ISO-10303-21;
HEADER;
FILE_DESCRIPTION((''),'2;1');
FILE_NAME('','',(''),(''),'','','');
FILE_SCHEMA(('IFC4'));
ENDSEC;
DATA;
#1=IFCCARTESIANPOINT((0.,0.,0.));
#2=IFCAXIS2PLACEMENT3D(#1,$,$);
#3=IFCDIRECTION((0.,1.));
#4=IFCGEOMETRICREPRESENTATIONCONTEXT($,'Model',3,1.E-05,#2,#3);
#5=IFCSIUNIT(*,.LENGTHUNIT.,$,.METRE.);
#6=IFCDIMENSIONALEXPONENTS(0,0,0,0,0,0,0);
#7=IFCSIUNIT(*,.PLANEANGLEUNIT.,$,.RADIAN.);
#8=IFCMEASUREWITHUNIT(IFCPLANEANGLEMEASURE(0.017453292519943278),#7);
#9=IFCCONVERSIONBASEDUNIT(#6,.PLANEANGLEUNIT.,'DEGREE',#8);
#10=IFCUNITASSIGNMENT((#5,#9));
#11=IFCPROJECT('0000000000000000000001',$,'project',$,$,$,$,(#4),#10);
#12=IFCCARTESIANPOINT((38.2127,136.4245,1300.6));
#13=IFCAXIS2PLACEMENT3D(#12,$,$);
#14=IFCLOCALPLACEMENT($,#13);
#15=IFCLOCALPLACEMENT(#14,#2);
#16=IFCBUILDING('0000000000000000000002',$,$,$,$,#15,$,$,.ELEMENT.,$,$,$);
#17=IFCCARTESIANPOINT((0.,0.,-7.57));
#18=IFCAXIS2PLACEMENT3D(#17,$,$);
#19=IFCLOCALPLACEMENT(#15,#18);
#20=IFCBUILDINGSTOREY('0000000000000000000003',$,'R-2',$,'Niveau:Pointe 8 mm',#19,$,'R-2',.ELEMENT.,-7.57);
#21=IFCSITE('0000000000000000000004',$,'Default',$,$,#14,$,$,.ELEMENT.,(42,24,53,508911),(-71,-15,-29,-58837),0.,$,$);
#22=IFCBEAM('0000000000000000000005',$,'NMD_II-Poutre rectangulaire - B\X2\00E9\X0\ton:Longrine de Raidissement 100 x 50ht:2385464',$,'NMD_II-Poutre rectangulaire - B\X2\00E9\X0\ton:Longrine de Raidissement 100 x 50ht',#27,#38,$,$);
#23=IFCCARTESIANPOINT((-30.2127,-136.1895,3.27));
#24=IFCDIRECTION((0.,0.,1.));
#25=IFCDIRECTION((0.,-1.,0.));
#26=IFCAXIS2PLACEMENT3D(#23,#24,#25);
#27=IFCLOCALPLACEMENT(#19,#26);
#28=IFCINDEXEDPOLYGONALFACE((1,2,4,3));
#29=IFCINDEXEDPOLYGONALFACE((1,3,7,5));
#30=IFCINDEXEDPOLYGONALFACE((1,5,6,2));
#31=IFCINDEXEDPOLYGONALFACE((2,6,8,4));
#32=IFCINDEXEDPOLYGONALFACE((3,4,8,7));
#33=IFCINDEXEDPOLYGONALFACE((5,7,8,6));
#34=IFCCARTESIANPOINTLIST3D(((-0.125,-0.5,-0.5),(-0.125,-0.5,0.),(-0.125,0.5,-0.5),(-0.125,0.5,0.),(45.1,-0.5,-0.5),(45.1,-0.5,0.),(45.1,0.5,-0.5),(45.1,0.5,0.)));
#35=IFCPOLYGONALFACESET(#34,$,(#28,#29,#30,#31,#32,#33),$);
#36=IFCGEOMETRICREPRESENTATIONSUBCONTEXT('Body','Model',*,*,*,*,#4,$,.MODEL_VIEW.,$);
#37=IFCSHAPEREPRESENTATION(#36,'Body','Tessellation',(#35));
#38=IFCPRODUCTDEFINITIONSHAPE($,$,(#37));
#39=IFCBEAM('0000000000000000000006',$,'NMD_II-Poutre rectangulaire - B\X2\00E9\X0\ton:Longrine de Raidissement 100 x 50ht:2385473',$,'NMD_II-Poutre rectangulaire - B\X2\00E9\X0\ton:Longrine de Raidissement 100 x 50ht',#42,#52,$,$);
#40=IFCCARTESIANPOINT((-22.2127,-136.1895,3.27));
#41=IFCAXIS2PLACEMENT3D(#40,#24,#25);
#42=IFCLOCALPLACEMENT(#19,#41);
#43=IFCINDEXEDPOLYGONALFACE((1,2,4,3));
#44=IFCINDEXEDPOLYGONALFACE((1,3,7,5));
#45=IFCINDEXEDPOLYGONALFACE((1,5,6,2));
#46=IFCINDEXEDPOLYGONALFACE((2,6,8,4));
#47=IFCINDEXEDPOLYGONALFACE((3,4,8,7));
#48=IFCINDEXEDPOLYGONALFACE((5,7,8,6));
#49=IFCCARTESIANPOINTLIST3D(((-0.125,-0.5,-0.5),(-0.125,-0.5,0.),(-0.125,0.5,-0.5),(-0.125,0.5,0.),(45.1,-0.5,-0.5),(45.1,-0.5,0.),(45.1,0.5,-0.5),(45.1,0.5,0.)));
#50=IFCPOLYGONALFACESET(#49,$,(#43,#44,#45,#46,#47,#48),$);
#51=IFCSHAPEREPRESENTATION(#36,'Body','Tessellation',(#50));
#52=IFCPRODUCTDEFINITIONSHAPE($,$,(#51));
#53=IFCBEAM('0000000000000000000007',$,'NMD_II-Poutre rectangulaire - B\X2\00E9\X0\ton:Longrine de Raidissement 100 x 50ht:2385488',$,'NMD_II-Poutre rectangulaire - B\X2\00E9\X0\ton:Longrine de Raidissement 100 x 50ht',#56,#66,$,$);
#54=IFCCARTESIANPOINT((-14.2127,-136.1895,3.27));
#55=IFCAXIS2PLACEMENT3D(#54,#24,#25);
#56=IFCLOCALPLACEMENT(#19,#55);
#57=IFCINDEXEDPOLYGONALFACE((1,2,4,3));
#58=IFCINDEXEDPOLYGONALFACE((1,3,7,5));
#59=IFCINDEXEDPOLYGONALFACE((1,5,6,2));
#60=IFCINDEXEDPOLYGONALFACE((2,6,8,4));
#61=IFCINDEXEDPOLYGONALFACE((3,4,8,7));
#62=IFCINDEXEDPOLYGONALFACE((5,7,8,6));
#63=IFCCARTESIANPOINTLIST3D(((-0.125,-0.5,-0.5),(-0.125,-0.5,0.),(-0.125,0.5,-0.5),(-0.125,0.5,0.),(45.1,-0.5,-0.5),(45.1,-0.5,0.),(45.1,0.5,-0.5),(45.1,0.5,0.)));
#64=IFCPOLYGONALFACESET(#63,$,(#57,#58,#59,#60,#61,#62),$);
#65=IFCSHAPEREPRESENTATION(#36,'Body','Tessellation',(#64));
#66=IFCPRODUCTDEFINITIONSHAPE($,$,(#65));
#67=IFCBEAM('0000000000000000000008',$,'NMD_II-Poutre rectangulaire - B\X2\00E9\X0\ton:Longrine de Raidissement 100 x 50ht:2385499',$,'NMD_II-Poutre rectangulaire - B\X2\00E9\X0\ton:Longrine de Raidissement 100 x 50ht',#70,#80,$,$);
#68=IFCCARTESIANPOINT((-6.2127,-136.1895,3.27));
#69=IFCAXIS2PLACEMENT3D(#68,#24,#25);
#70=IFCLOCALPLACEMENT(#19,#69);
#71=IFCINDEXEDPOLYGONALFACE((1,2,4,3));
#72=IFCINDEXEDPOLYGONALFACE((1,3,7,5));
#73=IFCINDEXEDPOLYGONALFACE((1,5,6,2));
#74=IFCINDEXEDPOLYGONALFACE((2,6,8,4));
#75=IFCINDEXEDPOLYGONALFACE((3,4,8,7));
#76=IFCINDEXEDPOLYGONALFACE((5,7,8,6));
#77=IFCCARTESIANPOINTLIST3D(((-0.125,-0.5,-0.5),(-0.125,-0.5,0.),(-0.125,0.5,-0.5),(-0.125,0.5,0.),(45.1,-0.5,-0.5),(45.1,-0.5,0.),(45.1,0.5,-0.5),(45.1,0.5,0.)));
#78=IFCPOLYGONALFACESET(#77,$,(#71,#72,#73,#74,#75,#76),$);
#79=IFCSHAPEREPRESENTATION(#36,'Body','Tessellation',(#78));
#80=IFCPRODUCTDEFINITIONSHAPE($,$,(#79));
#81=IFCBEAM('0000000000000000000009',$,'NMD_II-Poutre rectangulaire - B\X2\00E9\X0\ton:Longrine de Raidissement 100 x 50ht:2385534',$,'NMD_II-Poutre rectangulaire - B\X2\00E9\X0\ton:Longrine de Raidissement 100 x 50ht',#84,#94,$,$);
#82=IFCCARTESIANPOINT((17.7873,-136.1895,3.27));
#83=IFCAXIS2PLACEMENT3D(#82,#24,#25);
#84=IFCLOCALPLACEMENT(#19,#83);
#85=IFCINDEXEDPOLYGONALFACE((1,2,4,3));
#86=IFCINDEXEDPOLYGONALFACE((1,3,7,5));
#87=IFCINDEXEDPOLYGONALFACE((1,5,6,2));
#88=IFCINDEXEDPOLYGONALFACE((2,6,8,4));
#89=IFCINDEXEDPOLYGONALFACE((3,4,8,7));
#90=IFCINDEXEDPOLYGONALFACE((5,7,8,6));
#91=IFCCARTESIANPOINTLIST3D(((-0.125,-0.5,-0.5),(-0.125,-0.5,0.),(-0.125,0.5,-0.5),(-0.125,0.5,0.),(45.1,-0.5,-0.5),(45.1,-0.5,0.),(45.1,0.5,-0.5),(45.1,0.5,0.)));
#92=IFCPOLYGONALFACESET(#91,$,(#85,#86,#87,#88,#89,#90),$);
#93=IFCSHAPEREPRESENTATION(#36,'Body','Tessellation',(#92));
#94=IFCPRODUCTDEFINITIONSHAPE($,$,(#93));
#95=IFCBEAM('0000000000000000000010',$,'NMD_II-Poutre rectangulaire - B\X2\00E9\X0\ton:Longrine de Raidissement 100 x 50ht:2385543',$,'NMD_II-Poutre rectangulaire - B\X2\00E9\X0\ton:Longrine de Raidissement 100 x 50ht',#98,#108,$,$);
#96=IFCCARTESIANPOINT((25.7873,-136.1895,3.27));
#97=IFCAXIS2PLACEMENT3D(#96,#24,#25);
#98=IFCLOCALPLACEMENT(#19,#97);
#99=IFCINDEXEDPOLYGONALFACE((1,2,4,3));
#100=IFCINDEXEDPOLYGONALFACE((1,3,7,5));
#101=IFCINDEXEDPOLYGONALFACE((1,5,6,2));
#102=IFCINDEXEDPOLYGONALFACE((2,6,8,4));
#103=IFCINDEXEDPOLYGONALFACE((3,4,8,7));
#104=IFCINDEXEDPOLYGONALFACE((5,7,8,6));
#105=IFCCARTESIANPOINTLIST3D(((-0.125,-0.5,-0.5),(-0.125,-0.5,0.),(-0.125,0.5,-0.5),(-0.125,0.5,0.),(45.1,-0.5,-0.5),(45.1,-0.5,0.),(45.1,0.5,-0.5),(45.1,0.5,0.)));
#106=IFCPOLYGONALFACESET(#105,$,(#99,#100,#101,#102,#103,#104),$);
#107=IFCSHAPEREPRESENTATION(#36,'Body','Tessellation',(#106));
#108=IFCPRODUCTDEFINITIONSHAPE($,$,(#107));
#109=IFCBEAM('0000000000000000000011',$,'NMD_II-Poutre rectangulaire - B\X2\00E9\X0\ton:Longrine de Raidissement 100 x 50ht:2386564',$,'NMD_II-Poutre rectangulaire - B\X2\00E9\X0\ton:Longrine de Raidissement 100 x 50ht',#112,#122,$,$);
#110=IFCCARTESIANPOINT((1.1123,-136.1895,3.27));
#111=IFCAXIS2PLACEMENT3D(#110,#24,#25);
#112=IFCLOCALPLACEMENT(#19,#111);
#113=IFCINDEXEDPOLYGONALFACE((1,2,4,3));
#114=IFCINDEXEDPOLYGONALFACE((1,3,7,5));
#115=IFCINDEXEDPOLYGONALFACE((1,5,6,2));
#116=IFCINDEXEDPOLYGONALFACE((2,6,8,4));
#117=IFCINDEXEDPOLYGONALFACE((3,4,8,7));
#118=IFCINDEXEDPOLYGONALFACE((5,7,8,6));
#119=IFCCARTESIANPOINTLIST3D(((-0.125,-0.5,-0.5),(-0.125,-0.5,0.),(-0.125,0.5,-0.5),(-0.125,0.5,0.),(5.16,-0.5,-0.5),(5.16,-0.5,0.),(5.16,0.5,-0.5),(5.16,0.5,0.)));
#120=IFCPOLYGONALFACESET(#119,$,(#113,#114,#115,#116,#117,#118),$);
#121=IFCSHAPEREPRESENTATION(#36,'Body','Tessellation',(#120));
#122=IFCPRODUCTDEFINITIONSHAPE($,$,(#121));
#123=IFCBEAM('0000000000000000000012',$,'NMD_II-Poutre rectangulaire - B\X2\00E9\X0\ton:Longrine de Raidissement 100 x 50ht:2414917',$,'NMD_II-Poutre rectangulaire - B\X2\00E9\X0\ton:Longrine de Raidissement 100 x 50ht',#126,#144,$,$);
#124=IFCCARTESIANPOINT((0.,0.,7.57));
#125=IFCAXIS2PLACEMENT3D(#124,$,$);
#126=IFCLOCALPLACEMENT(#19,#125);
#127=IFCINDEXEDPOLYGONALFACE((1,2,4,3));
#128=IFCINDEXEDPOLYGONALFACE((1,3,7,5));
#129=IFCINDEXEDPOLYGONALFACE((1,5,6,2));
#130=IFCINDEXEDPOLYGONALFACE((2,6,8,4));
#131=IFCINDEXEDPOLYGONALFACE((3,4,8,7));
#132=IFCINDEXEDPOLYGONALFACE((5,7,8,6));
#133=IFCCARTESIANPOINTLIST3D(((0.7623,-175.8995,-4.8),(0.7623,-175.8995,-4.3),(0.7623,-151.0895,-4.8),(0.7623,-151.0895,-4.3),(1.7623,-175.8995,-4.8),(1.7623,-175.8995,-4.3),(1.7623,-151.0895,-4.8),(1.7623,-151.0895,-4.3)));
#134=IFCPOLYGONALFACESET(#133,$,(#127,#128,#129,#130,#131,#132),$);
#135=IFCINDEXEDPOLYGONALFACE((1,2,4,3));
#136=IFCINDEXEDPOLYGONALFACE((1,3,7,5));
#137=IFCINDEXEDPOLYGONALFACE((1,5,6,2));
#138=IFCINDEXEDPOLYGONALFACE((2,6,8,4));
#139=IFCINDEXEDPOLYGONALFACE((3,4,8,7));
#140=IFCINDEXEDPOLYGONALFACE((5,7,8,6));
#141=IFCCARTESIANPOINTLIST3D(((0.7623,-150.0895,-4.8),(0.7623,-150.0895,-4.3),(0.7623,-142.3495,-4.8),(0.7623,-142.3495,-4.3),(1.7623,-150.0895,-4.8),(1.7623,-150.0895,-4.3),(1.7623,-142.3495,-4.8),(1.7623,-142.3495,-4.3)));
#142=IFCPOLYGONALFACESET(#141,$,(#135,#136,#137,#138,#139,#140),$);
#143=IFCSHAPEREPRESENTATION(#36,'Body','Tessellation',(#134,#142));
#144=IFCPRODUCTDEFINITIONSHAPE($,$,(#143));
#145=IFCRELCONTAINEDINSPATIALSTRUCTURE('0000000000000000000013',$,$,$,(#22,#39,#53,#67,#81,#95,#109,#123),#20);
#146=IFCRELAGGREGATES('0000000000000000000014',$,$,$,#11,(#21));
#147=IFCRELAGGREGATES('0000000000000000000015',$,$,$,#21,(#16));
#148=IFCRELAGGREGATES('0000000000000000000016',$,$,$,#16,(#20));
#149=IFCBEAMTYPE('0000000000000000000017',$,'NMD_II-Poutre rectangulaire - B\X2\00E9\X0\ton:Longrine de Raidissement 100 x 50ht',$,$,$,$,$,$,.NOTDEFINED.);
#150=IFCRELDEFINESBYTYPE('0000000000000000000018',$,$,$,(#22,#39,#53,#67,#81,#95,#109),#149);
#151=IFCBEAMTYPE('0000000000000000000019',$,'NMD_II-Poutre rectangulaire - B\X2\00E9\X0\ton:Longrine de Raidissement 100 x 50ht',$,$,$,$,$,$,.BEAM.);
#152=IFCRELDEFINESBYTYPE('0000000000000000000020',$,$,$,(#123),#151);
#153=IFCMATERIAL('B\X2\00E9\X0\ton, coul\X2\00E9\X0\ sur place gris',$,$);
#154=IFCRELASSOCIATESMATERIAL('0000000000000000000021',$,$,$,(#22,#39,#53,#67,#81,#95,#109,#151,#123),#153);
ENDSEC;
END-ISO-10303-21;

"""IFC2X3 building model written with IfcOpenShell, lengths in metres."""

from ifc_helpers import new_model, entity, si_unit, converted_unit, direction, frame, frame_2d, origin, place, context, subcontext, project, spatial, rectangle, extrude, source, transform, mapped, material, type_object, type_shapes, element, save


model = new_model("IFC2X3")

# Units and contexts
model_context = context("Model", 3, precision=1e-05, world=origin(), true_north=direction((0.0, 1.0)))
body_context = subcontext(model_context, "Body", "Model", "MODEL_VIEW")
ifc_project = project(units=[si_unit("LENGTHUNIT", "METRE"), converted_unit("PLANEANGLEUNIT", "DEGREE", entity("IfcPlaneAngleMeasure", 0.017453292519943278), si_unit("PLANEANGLEUNIT", "RADIAN"), dimensions=[0, 0, 0, 0, 0, 0, 0])], contexts=[model_context])

# Site, building, storey
site_placement = place(None, frame((38.2127, 136.4245, 1300.6)))
site = spatial("IfcSite", under=ifc_project, at=site_placement, Name="Default", CompositionType="ELEMENT", RefLatitude=(42, 24, 53, 508911), RefLongitude=(-71, -15, -29, -58837), RefElevation=0.0)
building_placement = place(site_placement, origin())
building = spatial("IfcBuilding", under=site, at=building_placement, CompositionType="ELEMENT")
storey_placement = place(building_placement, frame((0.0, 0.0, -7.57)))
storey = spatial("IfcBuildingStorey", under=building, at=storey_placement, Name="R-2", ObjectType="Niveau:Pointe 8 mm", LongName="R-2", CompositionType="ELEMENT", Elevation=-7.57)

# Beams
ifc_material_1 = material(Name="Béton, coulé sur place gris")
beam_type_1 = type_object("IfcBeamType", Name="NMD_II-Poutre rectangulaire - Béton:Longrine de Raidissement 100 x 50ht", PredefinedType="NOTDEFINED")
beam_1_placement = place(storey_placement, frame((-30.2127, -136.1895, 3.27), z_axis=(0.0, 0.0, 1.0), x_axis=(0.0, -1.0, 0.0)))
element("IfcBeam", 1, at=beam_1_placement, inside=storey, type_object=beam_type_1, material=ifc_material_1, Name="NMD_II-Poutre rectangulaire - Béton:Longrine de Raidissement 100 x 50ht:2385464", ObjectType="NMD_II-Poutre rectangulaire - Béton:Longrine de Raidissement 100 x 50ht", context=body_context, shape_type="SweptSolid", body=[
    extrude(rectangle(XDim=0.5, YDim=1.0, at=frame_2d((0.0, 0.0), x_axis=(1.0, 0.0))), frame((-0.125, 0.0, -0.25), z_axis=(1.0, 0.0, 0.0), x_axis=(0.0, 0.0, -1.0)), (0.0, 0.0, 1.0), 45.225),
])
beam_2_placement = place(storey_placement, frame((-22.2127, -136.1895, 3.27), z_axis=(0.0, 0.0, 1.0), x_axis=(0.0, -1.0, 0.0)))
element("IfcBeam", 2, at=beam_2_placement, inside=storey, type_object=beam_type_1, material=ifc_material_1, Name="NMD_II-Poutre rectangulaire - Béton:Longrine de Raidissement 100 x 50ht:2385473", ObjectType="NMD_II-Poutre rectangulaire - Béton:Longrine de Raidissement 100 x 50ht", context=body_context, shape_type="SweptSolid", body=[
    extrude(rectangle(XDim=0.5, YDim=1.0, at=frame_2d((0.0, 0.0), x_axis=(1.0, 0.0))), frame((-0.125, 0.0, -0.25), z_axis=(1.0, 0.0, 0.0), x_axis=(0.0, 0.0, -1.0)), (0.0, 0.0, 1.0), 45.225),
])
beam_3_placement = place(storey_placement, frame((-14.2127, -136.1895, 3.27), z_axis=(0.0, 0.0, 1.0), x_axis=(0.0, -1.0, 0.0)))
element("IfcBeam", 3, at=beam_3_placement, inside=storey, type_object=beam_type_1, material=ifc_material_1, Name="NMD_II-Poutre rectangulaire - Béton:Longrine de Raidissement 100 x 50ht:2385488", ObjectType="NMD_II-Poutre rectangulaire - Béton:Longrine de Raidissement 100 x 50ht", context=body_context, shape_type="SweptSolid", body=[
    extrude(rectangle(XDim=0.5, YDim=1.0, at=frame_2d((0.0, 0.0), x_axis=(1.0, 0.0))), frame((-0.125, 0.0, -0.25), z_axis=(1.0, 0.0, 0.0), x_axis=(0.0, 0.0, -1.0)), (0.0, 0.0, 1.0), 45.225),
])
beam_4_placement = place(storey_placement, frame((-6.2127, -136.1895, 3.27), z_axis=(0.0, 0.0, 1.0), x_axis=(0.0, -1.0, 0.0)))
element("IfcBeam", 4, at=beam_4_placement, inside=storey, type_object=beam_type_1, material=ifc_material_1, Name="NMD_II-Poutre rectangulaire - Béton:Longrine de Raidissement 100 x 50ht:2385499", ObjectType="NMD_II-Poutre rectangulaire - Béton:Longrine de Raidissement 100 x 50ht", context=body_context, shape_type="SweptSolid", body=[
    extrude(rectangle(XDim=0.5, YDim=1.0, at=frame_2d((0.0, 0.0), x_axis=(1.0, 0.0))), frame((-0.125, 0.0, -0.25), z_axis=(1.0, 0.0, 0.0), x_axis=(0.0, 0.0, -1.0)), (0.0, 0.0, 1.0), 45.225),
])
beam_5_placement = place(storey_placement, frame((17.7873, -136.1895, 3.27), z_axis=(0.0, 0.0, 1.0), x_axis=(0.0, -1.0, 0.0)))
element("IfcBeam", 5, at=beam_5_placement, inside=storey, type_object=beam_type_1, material=ifc_material_1, Name="NMD_II-Poutre rectangulaire - Béton:Longrine de Raidissement 100 x 50ht:2385534", ObjectType="NMD_II-Poutre rectangulaire - Béton:Longrine de Raidissement 100 x 50ht", context=body_context, shape_type="SweptSolid", body=[
    extrude(rectangle(XDim=0.5, YDim=1.0, at=frame_2d((0.0, 0.0), x_axis=(1.0, 0.0))), frame((-0.125, 0.0, -0.25), z_axis=(1.0, 0.0, 0.0), x_axis=(0.0, 0.0, -1.0)), (0.0, 0.0, 1.0), 45.225),
])
beam_6_placement = place(storey_placement, frame((25.7873, -136.1895, 3.27), z_axis=(0.0, 0.0, 1.0), x_axis=(0.0, -1.0, 0.0)))
element("IfcBeam", 6, at=beam_6_placement, inside=storey, type_object=beam_type_1, material=ifc_material_1, Name="NMD_II-Poutre rectangulaire - Béton:Longrine de Raidissement 100 x 50ht:2385543", ObjectType="NMD_II-Poutre rectangulaire - Béton:Longrine de Raidissement 100 x 50ht", context=body_context, shape_type="SweptSolid", body=[
    extrude(rectangle(XDim=0.5, YDim=1.0, at=frame_2d((0.0, 0.0), x_axis=(1.0, 0.0))), frame((-0.125, 0.0, -0.25), z_axis=(1.0, 0.0, 0.0), x_axis=(0.0, 0.0, -1.0)), (0.0, 0.0, 1.0), 45.225),
])
beam_7_placement = place(storey_placement, frame((1.1123, -136.1895, 3.27), z_axis=(0.0, 0.0, 1.0), x_axis=(0.0, -1.0, 0.0)))
element("IfcBeam", 7, at=beam_7_placement, inside=storey, type_object=beam_type_1, material=ifc_material_1, Name="NMD_II-Poutre rectangulaire - Béton:Longrine de Raidissement 100 x 50ht:2386564", ObjectType="NMD_II-Poutre rectangulaire - Béton:Longrine de Raidissement 100 x 50ht", context=body_context, shape_type="SweptSolid", body=[
    extrude(rectangle(XDim=0.5, YDim=1.0, at=frame_2d((0.0, 0.0), x_axis=(1.0, 0.0))), frame((-0.125, 0.0, -0.25), z_axis=(1.0, 0.0, 0.0), x_axis=(0.0, 0.0, -1.0)), (0.0, 0.0, 1.0), 5.285),
])
beam_type_2 = type_object("IfcBeamType", Name="NMD_II-Poutre rectangulaire - Béton:Longrine de Raidissement 100 x 50ht", PredefinedType="BEAM", material=ifc_material_1)
shared_shape_1 = source(origin(), body_context, "Body", "SweptSolid", [
    extrude(rectangle(XDim=0.5, YDim=1.0, at=frame_2d((0.0, 0.0), x_axis=(0.0, 1.0))), frame((1.2623, -151.0895, -4.55), z_axis=(0.0, -1.0, 0.0), x_axis=(-1.0, 0.0, 0.0)), (0.0, 0.0, 1.0), 24.81),
    extrude(rectangle(XDim=0.5, YDim=1.0, at=frame_2d((0.0, 0.0), x_axis=(0.0, 1.0))), frame((1.2623, -142.3495, -4.55), z_axis=(0.0, -1.0, 0.0), x_axis=(-1.0, 0.0, 0.0)), (0.0, 0.0, 1.0), 7.74),
])
type_shapes(beam_type_2, [shared_shape_1])
beam_8_placement = place(storey_placement, frame((0.0, 0.0, 7.57)))
element("IfcBeam", 8, at=beam_8_placement, inside=storey, type_object=beam_type_2, material=ifc_material_1, Name="NMD_II-Poutre rectangulaire - Béton:Longrine de Raidissement 100 x 50ht:2414917", ObjectType="NMD_II-Poutre rectangulaire - Béton:Longrine de Raidissement 100 x 50ht", context=body_context, shape_type="MappedRepresentation", body=[
    mapped(shared_shape_1, transform((0.0, 0.0, 0.0), scale=1.0)),
])

save(model, "model.ifc")
